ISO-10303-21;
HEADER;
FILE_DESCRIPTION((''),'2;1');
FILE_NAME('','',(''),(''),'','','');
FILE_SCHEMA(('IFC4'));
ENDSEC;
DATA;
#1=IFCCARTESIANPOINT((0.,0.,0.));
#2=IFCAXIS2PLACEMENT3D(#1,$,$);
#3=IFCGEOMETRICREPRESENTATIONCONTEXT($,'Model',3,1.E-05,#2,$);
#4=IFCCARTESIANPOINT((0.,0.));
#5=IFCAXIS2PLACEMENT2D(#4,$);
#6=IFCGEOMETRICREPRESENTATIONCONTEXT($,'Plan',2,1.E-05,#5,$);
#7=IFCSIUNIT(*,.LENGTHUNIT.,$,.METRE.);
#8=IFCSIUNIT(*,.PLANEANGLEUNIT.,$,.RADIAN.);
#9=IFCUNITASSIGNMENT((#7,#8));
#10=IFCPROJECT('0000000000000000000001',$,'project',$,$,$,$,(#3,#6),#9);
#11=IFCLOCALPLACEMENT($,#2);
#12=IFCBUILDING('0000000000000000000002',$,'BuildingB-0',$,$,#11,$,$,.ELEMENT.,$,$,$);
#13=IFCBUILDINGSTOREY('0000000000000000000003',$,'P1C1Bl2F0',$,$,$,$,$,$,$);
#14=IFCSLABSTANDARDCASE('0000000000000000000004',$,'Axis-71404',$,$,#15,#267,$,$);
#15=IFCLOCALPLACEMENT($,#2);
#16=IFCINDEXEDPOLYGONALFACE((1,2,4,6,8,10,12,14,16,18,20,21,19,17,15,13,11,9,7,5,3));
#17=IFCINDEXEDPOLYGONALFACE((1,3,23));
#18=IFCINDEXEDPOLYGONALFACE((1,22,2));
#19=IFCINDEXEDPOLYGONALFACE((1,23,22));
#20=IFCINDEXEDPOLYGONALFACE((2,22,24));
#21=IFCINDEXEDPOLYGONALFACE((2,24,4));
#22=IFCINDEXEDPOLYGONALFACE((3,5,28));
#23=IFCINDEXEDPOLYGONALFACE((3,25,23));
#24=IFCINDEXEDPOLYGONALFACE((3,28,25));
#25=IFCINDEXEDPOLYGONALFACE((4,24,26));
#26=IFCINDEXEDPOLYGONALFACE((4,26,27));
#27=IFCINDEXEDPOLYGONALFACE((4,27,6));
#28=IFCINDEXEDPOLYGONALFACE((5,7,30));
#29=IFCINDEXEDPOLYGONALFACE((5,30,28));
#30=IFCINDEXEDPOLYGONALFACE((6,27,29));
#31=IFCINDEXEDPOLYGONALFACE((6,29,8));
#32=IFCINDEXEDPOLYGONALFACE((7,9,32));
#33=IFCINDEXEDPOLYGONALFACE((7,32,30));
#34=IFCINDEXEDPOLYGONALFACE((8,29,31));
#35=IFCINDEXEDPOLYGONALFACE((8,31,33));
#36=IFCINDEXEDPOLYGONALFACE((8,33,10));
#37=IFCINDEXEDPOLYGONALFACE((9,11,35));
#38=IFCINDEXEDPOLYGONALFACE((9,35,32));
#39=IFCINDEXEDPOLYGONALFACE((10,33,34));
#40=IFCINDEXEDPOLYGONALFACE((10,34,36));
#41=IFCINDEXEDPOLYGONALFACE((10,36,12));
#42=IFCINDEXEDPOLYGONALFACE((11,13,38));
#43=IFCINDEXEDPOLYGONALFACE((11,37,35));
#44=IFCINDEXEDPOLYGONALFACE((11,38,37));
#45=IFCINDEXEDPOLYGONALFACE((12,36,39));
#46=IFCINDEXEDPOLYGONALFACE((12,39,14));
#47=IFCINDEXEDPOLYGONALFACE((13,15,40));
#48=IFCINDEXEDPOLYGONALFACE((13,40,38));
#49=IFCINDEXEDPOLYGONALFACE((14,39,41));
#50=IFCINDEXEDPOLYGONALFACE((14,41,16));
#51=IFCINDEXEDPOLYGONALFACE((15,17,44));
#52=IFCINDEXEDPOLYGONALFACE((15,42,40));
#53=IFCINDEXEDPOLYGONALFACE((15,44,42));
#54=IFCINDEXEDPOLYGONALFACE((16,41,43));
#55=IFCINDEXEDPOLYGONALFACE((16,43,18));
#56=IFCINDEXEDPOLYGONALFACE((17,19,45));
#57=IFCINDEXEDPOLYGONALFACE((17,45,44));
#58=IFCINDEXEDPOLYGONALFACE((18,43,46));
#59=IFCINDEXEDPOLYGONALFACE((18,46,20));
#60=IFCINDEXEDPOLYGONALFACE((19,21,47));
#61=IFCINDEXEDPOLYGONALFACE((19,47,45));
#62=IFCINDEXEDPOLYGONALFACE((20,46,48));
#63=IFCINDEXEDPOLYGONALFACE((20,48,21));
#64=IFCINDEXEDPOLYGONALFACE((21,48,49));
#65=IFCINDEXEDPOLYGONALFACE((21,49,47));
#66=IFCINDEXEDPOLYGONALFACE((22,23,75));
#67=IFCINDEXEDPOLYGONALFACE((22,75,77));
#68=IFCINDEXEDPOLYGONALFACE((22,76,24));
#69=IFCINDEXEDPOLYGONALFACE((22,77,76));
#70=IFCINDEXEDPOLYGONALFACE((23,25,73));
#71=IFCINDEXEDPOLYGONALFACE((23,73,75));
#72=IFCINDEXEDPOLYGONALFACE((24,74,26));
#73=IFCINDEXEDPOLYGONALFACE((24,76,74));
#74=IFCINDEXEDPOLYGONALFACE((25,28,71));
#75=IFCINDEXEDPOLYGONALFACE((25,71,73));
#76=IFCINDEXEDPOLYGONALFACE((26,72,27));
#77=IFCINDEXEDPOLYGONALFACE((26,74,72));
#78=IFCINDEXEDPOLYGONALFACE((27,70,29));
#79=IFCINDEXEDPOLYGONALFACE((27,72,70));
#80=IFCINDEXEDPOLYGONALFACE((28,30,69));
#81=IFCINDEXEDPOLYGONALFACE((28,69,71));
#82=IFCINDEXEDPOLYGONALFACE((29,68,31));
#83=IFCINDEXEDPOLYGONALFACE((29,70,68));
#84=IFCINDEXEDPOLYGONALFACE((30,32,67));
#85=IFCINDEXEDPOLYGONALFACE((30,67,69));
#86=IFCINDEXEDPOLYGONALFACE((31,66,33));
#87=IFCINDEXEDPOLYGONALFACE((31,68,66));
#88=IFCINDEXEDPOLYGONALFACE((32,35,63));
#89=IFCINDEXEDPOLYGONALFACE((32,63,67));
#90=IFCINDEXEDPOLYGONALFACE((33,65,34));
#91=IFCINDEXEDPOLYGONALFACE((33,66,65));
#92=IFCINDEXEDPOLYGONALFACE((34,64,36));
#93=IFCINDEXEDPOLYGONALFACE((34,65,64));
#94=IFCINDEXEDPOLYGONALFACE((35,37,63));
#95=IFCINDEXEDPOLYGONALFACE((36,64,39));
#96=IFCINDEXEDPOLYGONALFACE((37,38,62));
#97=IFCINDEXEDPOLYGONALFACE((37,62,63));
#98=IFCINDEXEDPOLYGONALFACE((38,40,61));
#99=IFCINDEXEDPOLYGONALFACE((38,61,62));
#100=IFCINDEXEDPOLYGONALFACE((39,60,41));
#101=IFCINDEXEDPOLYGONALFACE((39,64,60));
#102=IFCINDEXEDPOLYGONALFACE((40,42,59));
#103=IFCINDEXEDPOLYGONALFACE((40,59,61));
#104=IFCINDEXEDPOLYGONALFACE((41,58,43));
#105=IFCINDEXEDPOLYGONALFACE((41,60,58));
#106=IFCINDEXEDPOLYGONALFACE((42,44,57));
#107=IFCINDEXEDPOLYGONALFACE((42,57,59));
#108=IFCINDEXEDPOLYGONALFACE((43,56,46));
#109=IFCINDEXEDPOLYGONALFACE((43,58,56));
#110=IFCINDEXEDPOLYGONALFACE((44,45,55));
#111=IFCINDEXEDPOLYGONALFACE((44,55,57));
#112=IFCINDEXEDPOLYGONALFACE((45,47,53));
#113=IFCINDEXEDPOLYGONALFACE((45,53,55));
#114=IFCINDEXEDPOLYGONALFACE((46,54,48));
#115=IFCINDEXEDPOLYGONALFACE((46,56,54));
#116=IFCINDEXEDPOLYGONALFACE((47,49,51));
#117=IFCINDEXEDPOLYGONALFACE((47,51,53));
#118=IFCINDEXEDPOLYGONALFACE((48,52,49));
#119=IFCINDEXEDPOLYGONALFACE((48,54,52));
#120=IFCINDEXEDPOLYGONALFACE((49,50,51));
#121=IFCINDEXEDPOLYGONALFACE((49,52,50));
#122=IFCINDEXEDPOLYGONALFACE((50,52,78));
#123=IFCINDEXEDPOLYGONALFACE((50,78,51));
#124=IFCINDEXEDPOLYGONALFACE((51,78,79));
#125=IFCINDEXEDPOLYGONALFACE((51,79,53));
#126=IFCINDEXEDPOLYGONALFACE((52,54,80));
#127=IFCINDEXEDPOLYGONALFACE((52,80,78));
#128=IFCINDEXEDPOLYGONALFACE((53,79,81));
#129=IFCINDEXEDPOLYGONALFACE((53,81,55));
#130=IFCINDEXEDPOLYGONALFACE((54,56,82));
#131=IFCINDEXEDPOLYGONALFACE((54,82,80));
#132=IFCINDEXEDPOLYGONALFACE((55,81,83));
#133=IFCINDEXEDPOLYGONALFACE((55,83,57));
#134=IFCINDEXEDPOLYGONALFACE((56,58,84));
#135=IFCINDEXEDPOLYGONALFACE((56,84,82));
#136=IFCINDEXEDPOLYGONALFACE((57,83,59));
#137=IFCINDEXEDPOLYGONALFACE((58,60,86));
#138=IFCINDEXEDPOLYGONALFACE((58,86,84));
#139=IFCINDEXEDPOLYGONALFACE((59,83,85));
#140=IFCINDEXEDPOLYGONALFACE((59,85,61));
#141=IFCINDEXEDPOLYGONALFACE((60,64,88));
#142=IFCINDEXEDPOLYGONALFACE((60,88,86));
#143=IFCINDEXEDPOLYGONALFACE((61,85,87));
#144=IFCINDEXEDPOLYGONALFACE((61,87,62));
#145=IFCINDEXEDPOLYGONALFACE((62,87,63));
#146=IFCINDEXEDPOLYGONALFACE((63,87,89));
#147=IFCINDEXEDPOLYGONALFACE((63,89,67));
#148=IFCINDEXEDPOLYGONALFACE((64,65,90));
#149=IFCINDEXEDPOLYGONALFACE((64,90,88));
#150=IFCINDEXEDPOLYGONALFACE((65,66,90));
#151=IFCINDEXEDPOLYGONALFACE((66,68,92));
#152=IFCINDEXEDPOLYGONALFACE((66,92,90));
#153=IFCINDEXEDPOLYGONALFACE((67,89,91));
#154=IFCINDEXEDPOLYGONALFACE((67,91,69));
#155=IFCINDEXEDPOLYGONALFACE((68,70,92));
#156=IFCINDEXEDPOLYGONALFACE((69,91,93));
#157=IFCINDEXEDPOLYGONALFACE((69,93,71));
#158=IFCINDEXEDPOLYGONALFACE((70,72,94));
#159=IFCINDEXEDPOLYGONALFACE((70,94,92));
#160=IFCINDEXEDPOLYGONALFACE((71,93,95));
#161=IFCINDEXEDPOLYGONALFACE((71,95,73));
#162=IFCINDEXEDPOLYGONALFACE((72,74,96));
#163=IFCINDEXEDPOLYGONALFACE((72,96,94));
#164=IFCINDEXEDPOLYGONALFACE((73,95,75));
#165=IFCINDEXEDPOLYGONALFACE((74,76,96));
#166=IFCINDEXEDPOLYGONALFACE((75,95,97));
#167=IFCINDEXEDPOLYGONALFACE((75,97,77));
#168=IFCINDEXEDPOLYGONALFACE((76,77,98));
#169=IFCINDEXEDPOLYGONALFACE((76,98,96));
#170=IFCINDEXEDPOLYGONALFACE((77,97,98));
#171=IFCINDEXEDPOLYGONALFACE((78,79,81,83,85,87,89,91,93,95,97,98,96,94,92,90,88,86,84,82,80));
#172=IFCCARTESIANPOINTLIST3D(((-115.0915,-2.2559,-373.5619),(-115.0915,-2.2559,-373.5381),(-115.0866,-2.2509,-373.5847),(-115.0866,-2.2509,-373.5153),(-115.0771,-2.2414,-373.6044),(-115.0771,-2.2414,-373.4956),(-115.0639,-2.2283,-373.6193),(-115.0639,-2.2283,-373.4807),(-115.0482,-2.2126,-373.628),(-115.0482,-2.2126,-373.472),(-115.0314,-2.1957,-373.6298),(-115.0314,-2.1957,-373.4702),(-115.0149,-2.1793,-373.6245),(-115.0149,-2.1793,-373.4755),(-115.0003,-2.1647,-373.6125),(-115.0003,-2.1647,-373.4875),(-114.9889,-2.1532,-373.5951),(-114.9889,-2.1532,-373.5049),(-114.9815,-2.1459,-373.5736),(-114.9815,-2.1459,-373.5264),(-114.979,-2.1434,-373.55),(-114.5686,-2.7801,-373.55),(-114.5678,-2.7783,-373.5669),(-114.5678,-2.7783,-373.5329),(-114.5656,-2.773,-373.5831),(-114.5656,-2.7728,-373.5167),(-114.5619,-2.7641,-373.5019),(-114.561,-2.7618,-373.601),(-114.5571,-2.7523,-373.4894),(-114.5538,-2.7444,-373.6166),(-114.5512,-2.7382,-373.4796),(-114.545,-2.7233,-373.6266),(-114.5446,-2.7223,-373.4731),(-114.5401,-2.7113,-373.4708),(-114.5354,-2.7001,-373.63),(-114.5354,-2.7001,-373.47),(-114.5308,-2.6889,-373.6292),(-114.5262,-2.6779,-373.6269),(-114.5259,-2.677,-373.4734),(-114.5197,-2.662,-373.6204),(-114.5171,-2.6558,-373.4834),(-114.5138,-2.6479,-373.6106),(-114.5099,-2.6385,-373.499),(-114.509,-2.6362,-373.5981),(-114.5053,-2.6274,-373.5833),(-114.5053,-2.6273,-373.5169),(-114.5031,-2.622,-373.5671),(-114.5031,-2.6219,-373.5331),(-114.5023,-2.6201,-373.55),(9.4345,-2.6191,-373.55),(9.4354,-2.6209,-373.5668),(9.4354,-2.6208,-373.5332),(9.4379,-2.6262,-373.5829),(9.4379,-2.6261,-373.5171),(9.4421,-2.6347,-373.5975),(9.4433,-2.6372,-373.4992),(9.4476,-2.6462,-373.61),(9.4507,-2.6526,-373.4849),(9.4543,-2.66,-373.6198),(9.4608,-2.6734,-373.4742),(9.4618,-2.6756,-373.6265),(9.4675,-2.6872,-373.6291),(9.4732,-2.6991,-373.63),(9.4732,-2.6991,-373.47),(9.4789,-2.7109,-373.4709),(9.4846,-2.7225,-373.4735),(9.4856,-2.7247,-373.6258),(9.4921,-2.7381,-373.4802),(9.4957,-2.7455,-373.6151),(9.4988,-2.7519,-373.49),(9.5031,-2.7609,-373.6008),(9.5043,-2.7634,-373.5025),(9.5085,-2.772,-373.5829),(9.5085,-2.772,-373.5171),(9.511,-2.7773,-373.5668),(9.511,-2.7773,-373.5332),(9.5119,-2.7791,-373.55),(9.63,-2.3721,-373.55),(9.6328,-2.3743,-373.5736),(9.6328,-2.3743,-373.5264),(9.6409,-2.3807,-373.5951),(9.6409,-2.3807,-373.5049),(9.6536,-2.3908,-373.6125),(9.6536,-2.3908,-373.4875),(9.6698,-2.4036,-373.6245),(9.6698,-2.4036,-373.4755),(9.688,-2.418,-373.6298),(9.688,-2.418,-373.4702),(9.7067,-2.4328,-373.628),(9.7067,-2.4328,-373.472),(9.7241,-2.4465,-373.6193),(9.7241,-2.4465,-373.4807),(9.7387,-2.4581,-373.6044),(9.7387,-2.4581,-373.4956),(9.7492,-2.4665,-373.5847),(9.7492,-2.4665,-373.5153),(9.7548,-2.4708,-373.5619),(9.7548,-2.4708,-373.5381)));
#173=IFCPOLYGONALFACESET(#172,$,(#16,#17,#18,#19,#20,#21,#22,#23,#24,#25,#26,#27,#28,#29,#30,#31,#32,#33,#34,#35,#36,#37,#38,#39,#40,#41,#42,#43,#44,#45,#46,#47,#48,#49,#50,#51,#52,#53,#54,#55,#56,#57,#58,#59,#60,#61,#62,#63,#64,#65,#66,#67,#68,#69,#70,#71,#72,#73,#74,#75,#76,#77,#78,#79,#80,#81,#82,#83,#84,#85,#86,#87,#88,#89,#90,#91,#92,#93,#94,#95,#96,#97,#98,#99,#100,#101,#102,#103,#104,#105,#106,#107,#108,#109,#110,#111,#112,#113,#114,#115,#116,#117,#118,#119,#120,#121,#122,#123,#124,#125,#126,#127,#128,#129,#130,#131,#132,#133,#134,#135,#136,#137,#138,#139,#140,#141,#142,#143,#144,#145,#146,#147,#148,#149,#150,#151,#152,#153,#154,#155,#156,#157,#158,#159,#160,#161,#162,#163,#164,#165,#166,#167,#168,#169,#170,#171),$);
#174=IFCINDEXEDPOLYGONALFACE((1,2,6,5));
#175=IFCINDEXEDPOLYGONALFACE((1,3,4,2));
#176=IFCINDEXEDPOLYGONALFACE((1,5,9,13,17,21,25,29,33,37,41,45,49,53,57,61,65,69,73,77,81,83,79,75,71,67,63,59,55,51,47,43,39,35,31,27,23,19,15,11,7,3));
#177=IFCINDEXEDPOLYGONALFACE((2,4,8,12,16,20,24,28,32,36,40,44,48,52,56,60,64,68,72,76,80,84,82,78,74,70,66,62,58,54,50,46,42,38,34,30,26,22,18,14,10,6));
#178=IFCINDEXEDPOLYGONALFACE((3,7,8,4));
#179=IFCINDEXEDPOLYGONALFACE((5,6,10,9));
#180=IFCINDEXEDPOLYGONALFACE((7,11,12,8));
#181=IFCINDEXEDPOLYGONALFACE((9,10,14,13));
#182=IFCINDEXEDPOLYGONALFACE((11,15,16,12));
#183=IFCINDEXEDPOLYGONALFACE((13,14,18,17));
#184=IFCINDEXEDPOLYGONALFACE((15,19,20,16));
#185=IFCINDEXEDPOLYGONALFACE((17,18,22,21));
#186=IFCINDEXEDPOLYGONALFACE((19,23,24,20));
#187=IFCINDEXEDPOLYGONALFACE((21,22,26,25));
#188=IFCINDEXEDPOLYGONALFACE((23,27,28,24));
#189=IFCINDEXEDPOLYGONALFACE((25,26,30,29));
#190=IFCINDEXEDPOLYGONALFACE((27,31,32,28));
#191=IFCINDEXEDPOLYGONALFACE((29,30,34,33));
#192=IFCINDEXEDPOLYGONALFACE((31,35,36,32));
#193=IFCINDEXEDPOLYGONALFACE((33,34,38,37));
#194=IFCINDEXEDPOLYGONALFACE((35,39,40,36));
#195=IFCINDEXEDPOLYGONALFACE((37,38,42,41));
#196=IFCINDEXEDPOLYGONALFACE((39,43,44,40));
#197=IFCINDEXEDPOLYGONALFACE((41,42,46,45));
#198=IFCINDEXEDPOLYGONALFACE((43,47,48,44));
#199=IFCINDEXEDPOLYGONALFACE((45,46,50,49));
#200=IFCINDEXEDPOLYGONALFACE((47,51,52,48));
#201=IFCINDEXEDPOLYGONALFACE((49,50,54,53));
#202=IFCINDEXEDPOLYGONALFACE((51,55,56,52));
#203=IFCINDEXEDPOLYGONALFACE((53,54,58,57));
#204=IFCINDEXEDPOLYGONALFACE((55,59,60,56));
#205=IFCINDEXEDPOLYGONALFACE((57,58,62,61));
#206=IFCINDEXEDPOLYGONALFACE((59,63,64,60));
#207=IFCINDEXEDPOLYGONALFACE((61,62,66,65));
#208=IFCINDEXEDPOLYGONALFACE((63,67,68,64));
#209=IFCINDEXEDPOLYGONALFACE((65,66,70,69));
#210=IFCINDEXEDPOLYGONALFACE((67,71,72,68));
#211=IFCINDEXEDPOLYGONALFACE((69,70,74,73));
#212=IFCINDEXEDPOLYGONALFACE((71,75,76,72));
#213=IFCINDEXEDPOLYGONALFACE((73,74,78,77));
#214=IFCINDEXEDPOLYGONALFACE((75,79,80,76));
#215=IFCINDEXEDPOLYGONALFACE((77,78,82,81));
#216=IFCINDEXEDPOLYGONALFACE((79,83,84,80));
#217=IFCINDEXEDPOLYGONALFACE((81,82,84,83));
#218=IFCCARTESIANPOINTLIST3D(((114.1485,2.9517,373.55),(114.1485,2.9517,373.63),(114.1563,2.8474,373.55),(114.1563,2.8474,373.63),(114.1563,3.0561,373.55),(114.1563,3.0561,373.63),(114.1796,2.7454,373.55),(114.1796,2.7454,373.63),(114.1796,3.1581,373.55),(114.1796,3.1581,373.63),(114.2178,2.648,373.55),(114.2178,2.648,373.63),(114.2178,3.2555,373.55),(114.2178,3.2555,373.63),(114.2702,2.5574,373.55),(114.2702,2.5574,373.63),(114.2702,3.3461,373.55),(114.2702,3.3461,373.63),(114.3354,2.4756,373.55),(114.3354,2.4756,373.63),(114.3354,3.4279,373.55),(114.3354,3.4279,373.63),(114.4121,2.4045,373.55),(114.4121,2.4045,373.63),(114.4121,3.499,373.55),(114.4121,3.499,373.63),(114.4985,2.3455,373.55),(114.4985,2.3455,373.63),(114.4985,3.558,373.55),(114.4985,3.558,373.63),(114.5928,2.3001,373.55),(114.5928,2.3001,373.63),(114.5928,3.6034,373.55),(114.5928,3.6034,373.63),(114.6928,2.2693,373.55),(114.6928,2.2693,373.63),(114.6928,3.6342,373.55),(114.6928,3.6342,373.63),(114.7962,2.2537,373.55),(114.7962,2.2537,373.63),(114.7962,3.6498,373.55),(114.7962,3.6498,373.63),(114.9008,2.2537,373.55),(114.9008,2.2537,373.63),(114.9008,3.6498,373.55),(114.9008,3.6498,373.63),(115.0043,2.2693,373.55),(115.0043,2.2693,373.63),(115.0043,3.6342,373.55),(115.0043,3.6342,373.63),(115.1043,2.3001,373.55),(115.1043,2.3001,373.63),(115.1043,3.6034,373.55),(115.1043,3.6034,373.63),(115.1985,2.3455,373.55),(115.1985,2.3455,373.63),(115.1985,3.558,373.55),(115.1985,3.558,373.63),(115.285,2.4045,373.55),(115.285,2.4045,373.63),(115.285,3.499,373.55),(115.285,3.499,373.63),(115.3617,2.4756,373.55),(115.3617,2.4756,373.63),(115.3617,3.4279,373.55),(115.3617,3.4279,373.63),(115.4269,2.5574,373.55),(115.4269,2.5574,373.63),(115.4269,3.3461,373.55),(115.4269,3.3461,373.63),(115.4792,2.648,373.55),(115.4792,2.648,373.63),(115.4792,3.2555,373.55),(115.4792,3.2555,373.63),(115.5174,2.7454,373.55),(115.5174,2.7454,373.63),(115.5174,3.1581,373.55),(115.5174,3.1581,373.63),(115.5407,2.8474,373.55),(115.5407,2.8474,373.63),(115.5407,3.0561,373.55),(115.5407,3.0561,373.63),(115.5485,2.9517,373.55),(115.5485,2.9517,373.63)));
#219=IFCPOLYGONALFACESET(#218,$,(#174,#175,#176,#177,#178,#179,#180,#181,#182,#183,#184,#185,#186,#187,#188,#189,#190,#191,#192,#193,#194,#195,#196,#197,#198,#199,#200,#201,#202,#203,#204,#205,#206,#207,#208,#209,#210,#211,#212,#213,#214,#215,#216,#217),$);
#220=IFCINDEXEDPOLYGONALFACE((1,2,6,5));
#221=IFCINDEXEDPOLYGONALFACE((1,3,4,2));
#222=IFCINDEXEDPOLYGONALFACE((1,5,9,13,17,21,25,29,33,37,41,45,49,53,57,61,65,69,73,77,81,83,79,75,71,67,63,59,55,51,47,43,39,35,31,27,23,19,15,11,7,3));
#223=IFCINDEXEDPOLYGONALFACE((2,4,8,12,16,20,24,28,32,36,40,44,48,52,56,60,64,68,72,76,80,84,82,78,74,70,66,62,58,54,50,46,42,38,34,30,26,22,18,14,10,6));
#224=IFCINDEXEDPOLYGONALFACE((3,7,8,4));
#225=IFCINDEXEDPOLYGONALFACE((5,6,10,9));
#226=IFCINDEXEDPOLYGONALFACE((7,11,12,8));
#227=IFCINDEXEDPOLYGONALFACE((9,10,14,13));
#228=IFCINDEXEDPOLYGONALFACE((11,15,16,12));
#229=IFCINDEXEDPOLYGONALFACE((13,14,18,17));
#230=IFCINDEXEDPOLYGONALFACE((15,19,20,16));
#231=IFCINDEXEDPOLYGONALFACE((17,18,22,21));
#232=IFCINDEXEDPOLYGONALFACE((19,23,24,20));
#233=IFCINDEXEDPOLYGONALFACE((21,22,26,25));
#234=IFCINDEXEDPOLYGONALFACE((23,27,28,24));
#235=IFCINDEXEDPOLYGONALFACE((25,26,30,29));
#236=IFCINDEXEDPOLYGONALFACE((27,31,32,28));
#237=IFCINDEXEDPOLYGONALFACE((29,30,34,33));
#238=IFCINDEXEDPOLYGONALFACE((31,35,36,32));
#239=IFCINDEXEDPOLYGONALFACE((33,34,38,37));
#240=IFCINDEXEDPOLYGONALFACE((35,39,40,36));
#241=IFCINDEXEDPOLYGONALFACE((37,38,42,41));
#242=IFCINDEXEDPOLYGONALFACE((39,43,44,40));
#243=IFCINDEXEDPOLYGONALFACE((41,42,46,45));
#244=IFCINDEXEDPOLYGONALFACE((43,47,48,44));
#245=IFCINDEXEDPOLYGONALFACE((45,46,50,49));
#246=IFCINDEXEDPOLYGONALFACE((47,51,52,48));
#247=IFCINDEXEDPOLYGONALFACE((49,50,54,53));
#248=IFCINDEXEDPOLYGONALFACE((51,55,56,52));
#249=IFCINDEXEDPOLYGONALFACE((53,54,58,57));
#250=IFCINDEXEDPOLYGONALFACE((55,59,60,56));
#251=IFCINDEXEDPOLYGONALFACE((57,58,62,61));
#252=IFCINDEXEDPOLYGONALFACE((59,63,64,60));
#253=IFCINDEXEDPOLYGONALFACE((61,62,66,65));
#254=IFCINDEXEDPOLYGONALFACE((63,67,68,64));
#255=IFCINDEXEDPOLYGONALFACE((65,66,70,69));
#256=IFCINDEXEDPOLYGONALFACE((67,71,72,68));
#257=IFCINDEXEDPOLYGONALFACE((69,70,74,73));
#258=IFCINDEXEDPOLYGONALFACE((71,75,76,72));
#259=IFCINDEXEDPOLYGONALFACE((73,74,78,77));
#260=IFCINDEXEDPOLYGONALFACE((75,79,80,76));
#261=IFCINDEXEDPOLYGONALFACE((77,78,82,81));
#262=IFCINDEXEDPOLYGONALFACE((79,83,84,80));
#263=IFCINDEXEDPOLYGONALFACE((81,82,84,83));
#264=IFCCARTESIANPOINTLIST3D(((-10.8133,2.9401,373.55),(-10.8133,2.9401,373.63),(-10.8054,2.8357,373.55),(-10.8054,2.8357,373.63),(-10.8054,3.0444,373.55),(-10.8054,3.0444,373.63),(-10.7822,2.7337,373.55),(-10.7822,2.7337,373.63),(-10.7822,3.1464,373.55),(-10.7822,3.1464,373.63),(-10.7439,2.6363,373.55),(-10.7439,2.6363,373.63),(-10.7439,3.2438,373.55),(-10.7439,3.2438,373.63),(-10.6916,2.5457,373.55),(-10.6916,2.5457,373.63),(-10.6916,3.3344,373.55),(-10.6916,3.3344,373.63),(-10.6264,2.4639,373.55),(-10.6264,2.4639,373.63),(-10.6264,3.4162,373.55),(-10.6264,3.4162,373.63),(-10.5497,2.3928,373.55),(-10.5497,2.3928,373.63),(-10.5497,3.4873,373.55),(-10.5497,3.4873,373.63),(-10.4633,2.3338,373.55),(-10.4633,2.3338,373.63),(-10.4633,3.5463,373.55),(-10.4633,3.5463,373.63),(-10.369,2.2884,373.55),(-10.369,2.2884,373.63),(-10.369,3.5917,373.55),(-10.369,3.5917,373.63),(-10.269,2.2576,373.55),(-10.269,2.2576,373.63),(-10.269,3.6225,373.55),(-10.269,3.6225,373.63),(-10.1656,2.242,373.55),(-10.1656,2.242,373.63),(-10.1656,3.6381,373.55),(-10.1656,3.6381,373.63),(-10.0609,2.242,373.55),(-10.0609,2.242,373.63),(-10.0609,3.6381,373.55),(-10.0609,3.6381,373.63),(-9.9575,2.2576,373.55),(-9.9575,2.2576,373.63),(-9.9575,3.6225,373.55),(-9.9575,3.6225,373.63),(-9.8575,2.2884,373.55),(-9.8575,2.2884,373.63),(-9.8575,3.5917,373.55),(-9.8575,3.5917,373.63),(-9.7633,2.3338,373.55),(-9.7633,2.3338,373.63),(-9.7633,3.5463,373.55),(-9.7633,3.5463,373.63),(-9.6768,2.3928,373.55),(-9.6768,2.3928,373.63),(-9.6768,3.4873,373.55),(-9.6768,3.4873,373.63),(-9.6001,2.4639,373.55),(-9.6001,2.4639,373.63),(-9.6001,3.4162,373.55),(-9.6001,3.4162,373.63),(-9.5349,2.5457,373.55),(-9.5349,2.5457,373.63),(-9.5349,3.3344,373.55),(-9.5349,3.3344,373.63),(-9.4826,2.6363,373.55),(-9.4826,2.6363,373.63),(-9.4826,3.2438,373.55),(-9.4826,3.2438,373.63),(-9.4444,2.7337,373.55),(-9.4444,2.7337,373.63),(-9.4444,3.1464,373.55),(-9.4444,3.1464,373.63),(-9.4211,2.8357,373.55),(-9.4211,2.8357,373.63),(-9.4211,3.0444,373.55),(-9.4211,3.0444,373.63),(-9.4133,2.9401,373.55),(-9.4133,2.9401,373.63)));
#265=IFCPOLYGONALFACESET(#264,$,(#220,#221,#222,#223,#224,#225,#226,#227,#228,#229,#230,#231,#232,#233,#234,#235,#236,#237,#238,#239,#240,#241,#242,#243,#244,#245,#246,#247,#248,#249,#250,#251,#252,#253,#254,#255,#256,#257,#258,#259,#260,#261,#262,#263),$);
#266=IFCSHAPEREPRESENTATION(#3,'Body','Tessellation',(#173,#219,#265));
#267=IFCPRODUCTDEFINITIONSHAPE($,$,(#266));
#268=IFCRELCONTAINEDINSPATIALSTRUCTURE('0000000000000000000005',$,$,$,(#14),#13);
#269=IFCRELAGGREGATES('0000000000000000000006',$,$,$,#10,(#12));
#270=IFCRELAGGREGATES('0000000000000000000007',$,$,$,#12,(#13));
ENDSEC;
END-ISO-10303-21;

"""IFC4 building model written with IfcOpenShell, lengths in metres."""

from ifc_helpers import new_model, entity, si_unit, frame, origin, origin_2d, place, context, project, spatial, circle, extrude, element, save


model = new_model("IFC4")

# Units and contexts
model_context = context("Model", 3, precision=1e-05, world=origin())
plan_context = context("Plan", 2, precision=1e-05, world=origin_2d())
ifc_project = project(units=[si_unit("LENGTHUNIT", "METRE"), si_unit("PLANEANGLEUNIT", "RADIAN")], contexts=[model_context, plan_context])

# Building, storey
building_placement = place(None, origin())
building = spatial("IfcBuilding", under=ifc_project, at=building_placement, Name="BuildingB-0", CompositionType="ELEMENT")
storey = spatial("IfcBuildingStorey", under=building, Name="P1C1Bl2F0")

# Slab
element("IfcSlabStandardCase", 1, inside=storey, Name="Axis-71404", context=model_context, shape_type="AdvancedSweptSolid", body=[
    entity("IfcSurfaceCurveSweptAreaSolid", entity("IfcCircleProfileDef", "AREA", None, None, 0.08), None, entity("IfcPolyline", [entity("IfcCartesianPoint", [114.8485, 2.7183, 373.55]), entity("IfcCartesianPoint", [114.629, 2.441, 373.55]), entity("IfcCartesianPoint", [-9.3797, 2.4399, 373.55]), entity("IfcCartesianPoint", [-9.8798, 2.9401, 373.55])]), None, None, entity("IfcPlane", entity("IfcAxis2Placement3D", entity("IfcCartesianPoint", [114.8485, 2.7183, 373.55]), entity("IfcDirection", [0.0, 0.0, 1.0]), entity("IfcDirection", [1.0, 0.0, 0.0])))),
    extrude(circle(Radius=0.7), frame((114.8485, 2.9517, 373.55)), (0.0, 0.0, 1.0), 0.08),
    extrude(circle(Radius=0.7), frame((-10.1133, 2.9401, 373.55)), (0.0, 0.0, 1.0), 0.08),
])

save(model, "model.ifc")
